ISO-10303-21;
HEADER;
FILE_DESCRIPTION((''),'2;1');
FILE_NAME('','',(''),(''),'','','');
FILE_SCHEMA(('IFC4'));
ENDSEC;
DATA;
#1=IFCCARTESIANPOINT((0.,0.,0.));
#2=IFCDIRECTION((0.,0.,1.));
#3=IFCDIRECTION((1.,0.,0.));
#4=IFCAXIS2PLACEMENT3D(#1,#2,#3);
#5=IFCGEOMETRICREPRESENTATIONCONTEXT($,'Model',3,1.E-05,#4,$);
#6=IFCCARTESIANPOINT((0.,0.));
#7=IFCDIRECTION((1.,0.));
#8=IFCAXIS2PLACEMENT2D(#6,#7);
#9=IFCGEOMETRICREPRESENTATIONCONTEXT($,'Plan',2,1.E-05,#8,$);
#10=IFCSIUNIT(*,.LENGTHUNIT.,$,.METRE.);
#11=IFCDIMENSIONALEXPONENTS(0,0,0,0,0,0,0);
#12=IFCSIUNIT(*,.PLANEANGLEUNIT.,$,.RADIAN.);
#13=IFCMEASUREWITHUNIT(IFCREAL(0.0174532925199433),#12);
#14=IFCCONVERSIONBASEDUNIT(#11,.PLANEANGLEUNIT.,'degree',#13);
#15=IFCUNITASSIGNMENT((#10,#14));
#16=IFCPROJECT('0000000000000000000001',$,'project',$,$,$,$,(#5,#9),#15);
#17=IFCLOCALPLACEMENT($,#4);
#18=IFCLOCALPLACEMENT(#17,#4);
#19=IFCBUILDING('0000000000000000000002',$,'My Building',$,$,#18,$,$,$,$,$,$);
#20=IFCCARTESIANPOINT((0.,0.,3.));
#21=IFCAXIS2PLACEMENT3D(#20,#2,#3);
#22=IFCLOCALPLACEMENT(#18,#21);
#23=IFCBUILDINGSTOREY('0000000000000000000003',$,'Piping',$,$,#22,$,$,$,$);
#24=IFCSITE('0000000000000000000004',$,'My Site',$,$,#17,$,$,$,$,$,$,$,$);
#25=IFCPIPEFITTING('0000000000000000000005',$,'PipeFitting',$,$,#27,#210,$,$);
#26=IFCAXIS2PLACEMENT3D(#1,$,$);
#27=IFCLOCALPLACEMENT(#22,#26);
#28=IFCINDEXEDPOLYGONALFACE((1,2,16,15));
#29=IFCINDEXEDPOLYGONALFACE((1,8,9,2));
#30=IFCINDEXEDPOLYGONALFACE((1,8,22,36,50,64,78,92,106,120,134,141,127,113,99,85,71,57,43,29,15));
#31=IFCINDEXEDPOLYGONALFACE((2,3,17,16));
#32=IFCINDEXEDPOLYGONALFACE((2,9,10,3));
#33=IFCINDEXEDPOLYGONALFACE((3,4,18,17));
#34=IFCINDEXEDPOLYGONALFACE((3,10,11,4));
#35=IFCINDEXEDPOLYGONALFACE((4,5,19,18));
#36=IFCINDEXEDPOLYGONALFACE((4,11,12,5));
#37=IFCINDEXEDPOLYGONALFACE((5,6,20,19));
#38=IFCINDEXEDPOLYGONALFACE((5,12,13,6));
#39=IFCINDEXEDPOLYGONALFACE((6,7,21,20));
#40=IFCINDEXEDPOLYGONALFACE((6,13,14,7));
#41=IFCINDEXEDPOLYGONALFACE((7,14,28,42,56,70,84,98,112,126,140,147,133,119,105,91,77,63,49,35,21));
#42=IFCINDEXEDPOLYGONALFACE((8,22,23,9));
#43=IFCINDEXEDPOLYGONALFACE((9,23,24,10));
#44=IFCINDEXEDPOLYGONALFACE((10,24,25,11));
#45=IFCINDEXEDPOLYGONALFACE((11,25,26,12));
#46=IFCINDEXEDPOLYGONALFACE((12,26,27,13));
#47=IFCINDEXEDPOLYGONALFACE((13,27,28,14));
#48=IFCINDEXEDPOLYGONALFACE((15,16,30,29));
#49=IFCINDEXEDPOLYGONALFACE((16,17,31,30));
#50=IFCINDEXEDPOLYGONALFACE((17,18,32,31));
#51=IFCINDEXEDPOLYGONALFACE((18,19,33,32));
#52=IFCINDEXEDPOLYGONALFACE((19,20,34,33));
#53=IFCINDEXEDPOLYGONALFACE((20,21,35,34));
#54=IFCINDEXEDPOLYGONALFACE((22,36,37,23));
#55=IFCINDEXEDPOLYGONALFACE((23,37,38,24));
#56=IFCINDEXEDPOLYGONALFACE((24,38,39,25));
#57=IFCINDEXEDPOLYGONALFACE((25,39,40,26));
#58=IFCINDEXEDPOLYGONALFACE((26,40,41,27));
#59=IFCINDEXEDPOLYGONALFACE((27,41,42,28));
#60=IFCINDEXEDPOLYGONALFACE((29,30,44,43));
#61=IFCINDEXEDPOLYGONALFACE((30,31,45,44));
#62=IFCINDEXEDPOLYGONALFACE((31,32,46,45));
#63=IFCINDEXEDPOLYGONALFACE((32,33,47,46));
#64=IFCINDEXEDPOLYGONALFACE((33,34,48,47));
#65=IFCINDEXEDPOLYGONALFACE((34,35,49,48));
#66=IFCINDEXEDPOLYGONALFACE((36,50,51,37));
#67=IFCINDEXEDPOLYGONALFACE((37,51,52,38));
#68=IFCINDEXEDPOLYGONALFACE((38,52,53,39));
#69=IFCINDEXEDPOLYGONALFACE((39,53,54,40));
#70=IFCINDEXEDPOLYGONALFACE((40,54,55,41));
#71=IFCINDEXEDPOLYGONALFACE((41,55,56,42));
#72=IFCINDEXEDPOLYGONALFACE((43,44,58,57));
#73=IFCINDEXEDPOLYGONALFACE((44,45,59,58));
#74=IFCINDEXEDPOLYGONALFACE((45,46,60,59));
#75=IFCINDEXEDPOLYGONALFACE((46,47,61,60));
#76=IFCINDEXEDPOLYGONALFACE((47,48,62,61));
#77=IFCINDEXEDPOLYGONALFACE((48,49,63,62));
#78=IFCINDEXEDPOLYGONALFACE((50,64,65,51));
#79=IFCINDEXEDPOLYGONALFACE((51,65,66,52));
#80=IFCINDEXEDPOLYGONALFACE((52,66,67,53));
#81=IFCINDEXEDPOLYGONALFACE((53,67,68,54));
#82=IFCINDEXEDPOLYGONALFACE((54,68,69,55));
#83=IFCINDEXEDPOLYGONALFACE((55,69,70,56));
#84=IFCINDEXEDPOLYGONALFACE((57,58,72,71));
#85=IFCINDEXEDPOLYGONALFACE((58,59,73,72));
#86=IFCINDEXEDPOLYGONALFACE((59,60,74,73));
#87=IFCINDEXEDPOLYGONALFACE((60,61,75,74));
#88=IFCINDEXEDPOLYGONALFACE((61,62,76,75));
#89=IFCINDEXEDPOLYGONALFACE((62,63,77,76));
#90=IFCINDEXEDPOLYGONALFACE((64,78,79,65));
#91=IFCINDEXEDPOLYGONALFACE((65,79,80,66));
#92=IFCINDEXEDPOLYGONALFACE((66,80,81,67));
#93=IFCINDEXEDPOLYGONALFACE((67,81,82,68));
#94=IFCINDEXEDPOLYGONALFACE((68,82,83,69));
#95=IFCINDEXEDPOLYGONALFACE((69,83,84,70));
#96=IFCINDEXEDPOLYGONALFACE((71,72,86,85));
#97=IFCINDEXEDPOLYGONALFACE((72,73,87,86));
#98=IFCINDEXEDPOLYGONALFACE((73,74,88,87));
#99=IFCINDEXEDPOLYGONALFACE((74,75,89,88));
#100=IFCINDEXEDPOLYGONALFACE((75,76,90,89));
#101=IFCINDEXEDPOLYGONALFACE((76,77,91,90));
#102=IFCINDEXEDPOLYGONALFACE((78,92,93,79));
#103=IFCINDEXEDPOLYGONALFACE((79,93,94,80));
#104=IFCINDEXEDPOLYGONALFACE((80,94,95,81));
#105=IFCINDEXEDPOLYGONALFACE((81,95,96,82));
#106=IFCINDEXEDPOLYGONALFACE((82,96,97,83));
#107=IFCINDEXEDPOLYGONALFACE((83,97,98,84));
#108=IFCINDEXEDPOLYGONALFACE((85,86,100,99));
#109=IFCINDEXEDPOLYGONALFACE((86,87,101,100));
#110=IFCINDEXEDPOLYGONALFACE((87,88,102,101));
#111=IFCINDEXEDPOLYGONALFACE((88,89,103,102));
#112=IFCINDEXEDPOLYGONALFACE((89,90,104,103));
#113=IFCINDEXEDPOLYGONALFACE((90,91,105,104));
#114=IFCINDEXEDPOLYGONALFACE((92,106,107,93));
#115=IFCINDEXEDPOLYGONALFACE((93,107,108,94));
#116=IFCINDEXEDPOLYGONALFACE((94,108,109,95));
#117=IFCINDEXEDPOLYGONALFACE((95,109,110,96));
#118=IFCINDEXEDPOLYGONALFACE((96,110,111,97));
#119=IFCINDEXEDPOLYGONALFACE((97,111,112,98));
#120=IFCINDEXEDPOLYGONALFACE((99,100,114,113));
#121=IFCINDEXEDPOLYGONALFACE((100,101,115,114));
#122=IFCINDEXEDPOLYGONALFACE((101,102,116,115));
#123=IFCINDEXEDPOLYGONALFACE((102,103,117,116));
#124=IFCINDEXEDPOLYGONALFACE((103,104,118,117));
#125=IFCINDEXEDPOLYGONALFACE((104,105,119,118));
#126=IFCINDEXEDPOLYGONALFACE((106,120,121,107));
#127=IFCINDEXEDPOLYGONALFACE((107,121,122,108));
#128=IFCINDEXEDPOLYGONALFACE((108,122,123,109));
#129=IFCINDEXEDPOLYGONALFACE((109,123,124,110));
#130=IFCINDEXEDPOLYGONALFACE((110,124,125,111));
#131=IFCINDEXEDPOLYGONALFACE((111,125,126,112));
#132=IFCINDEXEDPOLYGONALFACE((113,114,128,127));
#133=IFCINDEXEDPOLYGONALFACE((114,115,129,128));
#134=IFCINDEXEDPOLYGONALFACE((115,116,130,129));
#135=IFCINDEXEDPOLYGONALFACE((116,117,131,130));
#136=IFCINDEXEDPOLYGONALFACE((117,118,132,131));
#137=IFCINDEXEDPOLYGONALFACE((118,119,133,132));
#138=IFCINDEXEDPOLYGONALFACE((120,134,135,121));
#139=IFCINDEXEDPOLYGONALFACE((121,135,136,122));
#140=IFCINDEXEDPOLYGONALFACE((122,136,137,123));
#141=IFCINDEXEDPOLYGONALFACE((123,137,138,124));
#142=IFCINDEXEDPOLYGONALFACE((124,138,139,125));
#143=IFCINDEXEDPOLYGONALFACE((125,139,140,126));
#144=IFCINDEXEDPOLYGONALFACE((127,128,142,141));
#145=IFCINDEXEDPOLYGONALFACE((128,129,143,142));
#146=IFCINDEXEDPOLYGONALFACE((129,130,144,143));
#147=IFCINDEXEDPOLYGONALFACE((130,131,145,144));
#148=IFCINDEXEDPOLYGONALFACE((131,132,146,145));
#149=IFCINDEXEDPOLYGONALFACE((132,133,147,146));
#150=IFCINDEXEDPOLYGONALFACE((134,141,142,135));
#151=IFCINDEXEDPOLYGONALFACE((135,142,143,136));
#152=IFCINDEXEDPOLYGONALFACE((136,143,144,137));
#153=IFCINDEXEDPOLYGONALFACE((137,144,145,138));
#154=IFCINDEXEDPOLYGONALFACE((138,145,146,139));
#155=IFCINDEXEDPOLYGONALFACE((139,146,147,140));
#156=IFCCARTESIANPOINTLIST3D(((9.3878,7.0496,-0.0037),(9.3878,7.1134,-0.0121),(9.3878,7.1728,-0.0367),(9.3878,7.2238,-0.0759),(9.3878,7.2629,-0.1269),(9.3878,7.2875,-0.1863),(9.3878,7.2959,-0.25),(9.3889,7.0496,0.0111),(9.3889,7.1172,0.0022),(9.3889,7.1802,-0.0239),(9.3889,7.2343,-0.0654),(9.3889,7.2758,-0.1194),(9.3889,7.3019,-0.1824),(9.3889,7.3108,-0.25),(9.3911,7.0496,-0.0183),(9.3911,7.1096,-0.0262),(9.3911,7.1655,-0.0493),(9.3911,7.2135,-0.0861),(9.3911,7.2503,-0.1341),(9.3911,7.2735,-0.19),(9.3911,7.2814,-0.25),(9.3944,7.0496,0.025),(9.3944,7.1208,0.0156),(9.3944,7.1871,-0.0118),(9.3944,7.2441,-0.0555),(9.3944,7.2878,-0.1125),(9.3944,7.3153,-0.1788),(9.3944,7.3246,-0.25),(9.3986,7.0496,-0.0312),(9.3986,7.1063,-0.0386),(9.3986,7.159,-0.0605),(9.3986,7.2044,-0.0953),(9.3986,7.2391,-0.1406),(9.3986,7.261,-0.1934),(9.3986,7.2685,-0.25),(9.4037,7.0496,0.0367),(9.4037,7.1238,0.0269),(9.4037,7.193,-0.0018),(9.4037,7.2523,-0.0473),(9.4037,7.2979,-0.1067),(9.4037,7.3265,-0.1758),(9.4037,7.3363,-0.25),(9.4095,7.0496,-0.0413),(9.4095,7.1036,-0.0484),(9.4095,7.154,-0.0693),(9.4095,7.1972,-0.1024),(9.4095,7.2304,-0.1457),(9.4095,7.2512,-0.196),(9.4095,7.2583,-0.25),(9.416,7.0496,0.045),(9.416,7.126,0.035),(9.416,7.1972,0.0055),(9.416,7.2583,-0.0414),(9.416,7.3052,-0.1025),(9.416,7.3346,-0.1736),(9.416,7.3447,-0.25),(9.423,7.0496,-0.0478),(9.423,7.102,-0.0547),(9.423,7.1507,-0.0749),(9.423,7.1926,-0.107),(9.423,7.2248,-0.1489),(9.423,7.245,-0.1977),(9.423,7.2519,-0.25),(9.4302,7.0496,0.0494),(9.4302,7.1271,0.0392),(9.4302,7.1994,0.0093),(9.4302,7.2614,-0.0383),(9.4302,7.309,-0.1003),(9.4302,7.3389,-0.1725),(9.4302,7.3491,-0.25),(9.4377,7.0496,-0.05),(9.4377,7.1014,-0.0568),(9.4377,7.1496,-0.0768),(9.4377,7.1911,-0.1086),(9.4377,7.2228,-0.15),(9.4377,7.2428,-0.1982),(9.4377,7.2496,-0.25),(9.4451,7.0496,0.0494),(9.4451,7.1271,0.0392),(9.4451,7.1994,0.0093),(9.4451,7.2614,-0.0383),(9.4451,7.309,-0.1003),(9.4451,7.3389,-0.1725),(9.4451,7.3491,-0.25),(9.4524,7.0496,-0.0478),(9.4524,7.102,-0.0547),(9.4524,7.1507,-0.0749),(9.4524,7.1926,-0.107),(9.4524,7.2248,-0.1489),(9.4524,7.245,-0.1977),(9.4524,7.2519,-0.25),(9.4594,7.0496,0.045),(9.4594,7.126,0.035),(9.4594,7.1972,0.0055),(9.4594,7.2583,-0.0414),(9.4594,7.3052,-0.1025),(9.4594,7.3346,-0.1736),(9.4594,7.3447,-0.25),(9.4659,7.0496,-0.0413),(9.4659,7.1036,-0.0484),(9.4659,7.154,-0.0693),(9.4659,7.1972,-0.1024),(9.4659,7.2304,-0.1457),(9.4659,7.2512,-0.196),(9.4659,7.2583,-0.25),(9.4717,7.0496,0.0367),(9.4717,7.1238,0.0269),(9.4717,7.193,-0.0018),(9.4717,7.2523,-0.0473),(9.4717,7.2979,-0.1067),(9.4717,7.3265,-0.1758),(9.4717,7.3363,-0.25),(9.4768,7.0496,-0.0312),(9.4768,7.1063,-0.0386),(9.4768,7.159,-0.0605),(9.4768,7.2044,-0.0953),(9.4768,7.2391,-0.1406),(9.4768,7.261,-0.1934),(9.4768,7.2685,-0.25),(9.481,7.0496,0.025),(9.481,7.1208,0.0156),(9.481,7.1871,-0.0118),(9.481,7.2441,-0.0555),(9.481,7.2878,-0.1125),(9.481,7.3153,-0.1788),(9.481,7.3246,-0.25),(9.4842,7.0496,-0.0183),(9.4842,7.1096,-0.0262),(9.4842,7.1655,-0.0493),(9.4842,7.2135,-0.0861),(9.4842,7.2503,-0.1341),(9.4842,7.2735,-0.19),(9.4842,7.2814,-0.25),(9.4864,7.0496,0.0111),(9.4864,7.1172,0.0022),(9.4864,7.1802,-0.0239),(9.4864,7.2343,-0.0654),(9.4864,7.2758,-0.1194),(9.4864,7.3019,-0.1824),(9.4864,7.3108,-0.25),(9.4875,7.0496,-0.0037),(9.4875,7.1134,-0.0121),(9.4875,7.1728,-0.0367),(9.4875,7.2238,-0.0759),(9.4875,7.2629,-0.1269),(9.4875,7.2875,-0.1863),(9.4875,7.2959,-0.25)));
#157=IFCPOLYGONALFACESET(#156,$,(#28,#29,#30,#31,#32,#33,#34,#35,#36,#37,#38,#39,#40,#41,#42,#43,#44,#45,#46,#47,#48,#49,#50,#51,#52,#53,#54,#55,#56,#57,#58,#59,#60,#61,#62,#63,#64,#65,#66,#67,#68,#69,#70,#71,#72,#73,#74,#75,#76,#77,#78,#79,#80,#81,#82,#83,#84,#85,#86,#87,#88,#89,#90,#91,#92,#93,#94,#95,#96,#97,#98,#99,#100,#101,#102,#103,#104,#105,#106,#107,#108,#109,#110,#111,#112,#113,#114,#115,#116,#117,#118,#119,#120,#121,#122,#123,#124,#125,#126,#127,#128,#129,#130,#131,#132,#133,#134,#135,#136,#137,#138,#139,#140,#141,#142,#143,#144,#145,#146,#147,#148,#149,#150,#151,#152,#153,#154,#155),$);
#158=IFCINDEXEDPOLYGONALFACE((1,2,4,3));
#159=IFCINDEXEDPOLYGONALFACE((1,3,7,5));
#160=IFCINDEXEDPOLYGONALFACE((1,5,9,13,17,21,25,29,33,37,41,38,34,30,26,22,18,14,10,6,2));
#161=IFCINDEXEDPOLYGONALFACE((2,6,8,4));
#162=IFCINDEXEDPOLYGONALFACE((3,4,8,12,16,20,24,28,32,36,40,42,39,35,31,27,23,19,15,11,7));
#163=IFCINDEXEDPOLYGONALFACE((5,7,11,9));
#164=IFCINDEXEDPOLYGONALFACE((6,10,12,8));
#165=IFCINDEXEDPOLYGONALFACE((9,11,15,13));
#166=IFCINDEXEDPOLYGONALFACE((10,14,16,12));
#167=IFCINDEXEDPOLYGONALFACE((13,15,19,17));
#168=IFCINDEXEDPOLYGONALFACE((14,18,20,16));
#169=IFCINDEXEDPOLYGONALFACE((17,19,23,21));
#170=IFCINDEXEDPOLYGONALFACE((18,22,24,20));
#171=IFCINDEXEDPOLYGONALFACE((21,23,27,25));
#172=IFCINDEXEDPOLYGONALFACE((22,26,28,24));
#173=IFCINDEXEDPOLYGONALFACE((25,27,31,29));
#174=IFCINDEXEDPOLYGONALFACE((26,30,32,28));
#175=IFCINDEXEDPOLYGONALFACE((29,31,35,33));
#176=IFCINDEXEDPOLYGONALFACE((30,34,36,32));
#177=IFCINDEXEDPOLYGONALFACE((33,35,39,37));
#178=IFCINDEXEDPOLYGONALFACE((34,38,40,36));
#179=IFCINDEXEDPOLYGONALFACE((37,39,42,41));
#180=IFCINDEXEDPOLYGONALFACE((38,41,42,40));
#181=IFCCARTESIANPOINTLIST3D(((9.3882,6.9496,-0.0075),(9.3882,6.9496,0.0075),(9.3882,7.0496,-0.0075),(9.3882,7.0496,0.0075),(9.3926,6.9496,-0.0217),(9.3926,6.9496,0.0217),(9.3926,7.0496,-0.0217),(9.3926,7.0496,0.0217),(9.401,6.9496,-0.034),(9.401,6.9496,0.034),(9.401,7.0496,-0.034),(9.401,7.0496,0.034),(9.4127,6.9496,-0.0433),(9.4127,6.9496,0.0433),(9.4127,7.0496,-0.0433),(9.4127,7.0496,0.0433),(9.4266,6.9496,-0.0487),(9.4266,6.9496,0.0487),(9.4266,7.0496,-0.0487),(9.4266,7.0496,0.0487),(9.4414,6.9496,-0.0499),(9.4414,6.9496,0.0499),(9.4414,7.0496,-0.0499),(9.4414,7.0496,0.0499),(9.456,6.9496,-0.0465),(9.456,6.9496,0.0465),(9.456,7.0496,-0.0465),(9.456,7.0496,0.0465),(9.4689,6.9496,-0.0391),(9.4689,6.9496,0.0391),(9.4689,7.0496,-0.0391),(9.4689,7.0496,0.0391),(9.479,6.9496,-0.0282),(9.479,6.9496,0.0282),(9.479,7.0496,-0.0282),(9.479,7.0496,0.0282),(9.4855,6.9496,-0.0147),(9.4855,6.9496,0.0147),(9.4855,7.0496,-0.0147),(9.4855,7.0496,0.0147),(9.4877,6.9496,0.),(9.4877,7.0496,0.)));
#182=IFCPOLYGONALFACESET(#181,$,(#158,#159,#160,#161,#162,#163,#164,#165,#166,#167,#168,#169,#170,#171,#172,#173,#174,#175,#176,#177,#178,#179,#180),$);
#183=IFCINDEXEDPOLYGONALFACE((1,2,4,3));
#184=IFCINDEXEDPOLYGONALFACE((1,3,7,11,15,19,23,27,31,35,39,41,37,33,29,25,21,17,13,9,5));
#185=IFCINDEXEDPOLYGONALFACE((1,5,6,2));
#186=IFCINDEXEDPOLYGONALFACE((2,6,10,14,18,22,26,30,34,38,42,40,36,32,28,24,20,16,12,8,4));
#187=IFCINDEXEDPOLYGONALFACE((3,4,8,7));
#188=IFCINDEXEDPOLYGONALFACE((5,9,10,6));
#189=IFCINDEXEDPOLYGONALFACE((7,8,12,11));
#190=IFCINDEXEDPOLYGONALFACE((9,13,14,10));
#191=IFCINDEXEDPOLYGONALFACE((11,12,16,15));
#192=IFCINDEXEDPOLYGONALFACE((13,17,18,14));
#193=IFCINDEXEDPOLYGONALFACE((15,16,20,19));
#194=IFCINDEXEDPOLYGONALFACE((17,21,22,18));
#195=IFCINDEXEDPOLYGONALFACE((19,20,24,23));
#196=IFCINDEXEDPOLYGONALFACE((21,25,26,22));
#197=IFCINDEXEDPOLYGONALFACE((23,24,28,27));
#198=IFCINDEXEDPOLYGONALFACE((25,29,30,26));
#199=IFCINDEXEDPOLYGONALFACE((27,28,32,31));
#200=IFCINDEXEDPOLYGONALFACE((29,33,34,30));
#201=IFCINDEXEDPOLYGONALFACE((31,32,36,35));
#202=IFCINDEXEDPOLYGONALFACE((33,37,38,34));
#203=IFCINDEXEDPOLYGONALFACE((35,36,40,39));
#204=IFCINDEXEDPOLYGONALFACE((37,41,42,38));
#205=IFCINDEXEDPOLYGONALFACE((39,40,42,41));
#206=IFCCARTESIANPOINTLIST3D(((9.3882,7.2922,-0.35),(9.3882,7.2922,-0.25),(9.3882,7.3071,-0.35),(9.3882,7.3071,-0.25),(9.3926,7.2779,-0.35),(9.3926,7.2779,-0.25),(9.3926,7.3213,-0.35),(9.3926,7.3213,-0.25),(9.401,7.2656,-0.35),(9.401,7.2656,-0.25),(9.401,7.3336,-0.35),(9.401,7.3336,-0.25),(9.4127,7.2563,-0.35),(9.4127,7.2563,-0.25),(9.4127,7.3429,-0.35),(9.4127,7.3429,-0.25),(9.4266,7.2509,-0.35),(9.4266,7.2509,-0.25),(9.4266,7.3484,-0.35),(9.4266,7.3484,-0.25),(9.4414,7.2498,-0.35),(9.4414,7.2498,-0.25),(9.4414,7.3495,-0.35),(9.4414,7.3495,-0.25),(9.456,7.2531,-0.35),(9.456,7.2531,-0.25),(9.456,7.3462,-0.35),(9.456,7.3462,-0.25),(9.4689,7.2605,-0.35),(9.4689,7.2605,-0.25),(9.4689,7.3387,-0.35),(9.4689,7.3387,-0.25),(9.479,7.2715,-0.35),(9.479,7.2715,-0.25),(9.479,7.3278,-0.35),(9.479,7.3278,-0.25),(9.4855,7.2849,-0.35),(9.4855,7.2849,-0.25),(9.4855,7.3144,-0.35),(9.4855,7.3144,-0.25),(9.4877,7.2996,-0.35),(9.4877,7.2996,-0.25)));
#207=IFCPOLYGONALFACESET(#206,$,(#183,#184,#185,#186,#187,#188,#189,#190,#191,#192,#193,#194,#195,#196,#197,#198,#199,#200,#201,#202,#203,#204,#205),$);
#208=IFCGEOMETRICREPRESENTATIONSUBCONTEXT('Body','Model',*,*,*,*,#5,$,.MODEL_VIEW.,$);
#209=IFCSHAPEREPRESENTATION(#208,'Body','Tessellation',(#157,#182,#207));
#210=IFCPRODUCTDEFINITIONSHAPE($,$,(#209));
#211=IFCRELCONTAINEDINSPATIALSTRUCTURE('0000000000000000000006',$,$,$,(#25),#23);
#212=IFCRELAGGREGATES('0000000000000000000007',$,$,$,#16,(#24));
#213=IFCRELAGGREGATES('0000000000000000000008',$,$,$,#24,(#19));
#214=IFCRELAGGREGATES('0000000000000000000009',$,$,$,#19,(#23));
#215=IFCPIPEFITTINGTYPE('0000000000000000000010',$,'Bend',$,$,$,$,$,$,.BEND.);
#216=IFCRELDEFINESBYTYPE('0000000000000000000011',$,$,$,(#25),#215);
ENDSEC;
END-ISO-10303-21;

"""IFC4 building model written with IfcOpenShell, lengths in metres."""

from ifc_helpers import new_model, entity, si_unit, converted_unit, frame, origin_with_axes, origin_2d_with_axis, place, context, subcontext, project, spatial, circle, extrude, source, transform, mapped, type_object, type_shapes, element, save


model = new_model("IFC4")

# Units and contexts
model_context = context("Model", 3, precision=1e-05, world=origin_with_axes())
plan_context = context("Plan", 2, precision=1e-05, world=origin_2d_with_axis())
body_context = subcontext(model_context, "Body", "Model", "MODEL_VIEW")
ifc_project = project(units=[si_unit("LENGTHUNIT", "METRE"), converted_unit("PLANEANGLEUNIT", "degree", entity("IfcReal", 0.0174532925199433), si_unit("PLANEANGLEUNIT", "RADIAN"), dimensions=[0, 0, 0, 0, 0, 0, 0])], contexts=[model_context, plan_context])

# Site, building, storey
site_placement = place(None, origin_with_axes())
site = spatial("IfcSite", under=ifc_project, at=site_placement, Name="My Site")
building_placement = place(site_placement, origin_with_axes())
building = spatial("IfcBuilding", under=site, at=building_placement, Name="My Building")
storey_placement = place(building_placement, frame((0.0, 0.0, 3.0), z_axis=(0.0, 0.0, 1.0), x_axis=(1.0, 0.0, 0.0)))
storey = spatial("IfcBuildingStorey", under=building, at=storey_placement, Name="Piping")

# Pipe fitting
pipe_fitting_type = type_object("IfcPipeFittingType", Name="Bend", PredefinedType="BEND")
shared_shape = source(origin_with_axes(), body_context, "Body", "SolidModel", [
    entity("IfcSweptDiskSolid", entity("IfcIndexedPolyCurve", entity("IfcCartesianPointList3D", [[0.0, 0.0, -0.1], [0.0, -0.0732, -0.2768], [0.0, -0.25, -0.35]]), [entity("IfcArcIndex", [1, 2, 3])]), 0.05),
    extrude(circle(Radius=0.05), origin_with_axes(), (0.0, 0.0, -1.0), 0.1),
    extrude(circle(Radius=0.05), frame((0.0, -0.25, -0.35), z_axis=(0.0, -1.0, 0.0), x_axis=(1.0, 0.0, 0.0)), (0.0, 0.0, 1.0), 0.1),
])
type_shapes(pipe_fitting_type, [shared_shape])
for number, where, z_axis, x_axis, name in (
    (1, (9.4377, 6.9496, 0.0), (0.0, -1.0, 0.0), (1.0, 0.0, 0.0), "PipeFitting"),
):
    element("IfcPipeFitting", number, at=place(storey_placement, frame(where, z_axis=z_axis, x_axis=x_axis)), inside=storey, type_object=pipe_fitting_type, Name=name, context=body_context, shape_type="MappedRepresentation", body=[
        mapped(shared_shape, transform((0.0, 0.0, 0.0), x_axis=(1.0, 0.0, 0.0), y_axis=(0.0, 1.0, 0.0), z_axis=(0.0, 0.0, 1.0), scale=1.0)),
    ])

save(model, "model.ifc")
